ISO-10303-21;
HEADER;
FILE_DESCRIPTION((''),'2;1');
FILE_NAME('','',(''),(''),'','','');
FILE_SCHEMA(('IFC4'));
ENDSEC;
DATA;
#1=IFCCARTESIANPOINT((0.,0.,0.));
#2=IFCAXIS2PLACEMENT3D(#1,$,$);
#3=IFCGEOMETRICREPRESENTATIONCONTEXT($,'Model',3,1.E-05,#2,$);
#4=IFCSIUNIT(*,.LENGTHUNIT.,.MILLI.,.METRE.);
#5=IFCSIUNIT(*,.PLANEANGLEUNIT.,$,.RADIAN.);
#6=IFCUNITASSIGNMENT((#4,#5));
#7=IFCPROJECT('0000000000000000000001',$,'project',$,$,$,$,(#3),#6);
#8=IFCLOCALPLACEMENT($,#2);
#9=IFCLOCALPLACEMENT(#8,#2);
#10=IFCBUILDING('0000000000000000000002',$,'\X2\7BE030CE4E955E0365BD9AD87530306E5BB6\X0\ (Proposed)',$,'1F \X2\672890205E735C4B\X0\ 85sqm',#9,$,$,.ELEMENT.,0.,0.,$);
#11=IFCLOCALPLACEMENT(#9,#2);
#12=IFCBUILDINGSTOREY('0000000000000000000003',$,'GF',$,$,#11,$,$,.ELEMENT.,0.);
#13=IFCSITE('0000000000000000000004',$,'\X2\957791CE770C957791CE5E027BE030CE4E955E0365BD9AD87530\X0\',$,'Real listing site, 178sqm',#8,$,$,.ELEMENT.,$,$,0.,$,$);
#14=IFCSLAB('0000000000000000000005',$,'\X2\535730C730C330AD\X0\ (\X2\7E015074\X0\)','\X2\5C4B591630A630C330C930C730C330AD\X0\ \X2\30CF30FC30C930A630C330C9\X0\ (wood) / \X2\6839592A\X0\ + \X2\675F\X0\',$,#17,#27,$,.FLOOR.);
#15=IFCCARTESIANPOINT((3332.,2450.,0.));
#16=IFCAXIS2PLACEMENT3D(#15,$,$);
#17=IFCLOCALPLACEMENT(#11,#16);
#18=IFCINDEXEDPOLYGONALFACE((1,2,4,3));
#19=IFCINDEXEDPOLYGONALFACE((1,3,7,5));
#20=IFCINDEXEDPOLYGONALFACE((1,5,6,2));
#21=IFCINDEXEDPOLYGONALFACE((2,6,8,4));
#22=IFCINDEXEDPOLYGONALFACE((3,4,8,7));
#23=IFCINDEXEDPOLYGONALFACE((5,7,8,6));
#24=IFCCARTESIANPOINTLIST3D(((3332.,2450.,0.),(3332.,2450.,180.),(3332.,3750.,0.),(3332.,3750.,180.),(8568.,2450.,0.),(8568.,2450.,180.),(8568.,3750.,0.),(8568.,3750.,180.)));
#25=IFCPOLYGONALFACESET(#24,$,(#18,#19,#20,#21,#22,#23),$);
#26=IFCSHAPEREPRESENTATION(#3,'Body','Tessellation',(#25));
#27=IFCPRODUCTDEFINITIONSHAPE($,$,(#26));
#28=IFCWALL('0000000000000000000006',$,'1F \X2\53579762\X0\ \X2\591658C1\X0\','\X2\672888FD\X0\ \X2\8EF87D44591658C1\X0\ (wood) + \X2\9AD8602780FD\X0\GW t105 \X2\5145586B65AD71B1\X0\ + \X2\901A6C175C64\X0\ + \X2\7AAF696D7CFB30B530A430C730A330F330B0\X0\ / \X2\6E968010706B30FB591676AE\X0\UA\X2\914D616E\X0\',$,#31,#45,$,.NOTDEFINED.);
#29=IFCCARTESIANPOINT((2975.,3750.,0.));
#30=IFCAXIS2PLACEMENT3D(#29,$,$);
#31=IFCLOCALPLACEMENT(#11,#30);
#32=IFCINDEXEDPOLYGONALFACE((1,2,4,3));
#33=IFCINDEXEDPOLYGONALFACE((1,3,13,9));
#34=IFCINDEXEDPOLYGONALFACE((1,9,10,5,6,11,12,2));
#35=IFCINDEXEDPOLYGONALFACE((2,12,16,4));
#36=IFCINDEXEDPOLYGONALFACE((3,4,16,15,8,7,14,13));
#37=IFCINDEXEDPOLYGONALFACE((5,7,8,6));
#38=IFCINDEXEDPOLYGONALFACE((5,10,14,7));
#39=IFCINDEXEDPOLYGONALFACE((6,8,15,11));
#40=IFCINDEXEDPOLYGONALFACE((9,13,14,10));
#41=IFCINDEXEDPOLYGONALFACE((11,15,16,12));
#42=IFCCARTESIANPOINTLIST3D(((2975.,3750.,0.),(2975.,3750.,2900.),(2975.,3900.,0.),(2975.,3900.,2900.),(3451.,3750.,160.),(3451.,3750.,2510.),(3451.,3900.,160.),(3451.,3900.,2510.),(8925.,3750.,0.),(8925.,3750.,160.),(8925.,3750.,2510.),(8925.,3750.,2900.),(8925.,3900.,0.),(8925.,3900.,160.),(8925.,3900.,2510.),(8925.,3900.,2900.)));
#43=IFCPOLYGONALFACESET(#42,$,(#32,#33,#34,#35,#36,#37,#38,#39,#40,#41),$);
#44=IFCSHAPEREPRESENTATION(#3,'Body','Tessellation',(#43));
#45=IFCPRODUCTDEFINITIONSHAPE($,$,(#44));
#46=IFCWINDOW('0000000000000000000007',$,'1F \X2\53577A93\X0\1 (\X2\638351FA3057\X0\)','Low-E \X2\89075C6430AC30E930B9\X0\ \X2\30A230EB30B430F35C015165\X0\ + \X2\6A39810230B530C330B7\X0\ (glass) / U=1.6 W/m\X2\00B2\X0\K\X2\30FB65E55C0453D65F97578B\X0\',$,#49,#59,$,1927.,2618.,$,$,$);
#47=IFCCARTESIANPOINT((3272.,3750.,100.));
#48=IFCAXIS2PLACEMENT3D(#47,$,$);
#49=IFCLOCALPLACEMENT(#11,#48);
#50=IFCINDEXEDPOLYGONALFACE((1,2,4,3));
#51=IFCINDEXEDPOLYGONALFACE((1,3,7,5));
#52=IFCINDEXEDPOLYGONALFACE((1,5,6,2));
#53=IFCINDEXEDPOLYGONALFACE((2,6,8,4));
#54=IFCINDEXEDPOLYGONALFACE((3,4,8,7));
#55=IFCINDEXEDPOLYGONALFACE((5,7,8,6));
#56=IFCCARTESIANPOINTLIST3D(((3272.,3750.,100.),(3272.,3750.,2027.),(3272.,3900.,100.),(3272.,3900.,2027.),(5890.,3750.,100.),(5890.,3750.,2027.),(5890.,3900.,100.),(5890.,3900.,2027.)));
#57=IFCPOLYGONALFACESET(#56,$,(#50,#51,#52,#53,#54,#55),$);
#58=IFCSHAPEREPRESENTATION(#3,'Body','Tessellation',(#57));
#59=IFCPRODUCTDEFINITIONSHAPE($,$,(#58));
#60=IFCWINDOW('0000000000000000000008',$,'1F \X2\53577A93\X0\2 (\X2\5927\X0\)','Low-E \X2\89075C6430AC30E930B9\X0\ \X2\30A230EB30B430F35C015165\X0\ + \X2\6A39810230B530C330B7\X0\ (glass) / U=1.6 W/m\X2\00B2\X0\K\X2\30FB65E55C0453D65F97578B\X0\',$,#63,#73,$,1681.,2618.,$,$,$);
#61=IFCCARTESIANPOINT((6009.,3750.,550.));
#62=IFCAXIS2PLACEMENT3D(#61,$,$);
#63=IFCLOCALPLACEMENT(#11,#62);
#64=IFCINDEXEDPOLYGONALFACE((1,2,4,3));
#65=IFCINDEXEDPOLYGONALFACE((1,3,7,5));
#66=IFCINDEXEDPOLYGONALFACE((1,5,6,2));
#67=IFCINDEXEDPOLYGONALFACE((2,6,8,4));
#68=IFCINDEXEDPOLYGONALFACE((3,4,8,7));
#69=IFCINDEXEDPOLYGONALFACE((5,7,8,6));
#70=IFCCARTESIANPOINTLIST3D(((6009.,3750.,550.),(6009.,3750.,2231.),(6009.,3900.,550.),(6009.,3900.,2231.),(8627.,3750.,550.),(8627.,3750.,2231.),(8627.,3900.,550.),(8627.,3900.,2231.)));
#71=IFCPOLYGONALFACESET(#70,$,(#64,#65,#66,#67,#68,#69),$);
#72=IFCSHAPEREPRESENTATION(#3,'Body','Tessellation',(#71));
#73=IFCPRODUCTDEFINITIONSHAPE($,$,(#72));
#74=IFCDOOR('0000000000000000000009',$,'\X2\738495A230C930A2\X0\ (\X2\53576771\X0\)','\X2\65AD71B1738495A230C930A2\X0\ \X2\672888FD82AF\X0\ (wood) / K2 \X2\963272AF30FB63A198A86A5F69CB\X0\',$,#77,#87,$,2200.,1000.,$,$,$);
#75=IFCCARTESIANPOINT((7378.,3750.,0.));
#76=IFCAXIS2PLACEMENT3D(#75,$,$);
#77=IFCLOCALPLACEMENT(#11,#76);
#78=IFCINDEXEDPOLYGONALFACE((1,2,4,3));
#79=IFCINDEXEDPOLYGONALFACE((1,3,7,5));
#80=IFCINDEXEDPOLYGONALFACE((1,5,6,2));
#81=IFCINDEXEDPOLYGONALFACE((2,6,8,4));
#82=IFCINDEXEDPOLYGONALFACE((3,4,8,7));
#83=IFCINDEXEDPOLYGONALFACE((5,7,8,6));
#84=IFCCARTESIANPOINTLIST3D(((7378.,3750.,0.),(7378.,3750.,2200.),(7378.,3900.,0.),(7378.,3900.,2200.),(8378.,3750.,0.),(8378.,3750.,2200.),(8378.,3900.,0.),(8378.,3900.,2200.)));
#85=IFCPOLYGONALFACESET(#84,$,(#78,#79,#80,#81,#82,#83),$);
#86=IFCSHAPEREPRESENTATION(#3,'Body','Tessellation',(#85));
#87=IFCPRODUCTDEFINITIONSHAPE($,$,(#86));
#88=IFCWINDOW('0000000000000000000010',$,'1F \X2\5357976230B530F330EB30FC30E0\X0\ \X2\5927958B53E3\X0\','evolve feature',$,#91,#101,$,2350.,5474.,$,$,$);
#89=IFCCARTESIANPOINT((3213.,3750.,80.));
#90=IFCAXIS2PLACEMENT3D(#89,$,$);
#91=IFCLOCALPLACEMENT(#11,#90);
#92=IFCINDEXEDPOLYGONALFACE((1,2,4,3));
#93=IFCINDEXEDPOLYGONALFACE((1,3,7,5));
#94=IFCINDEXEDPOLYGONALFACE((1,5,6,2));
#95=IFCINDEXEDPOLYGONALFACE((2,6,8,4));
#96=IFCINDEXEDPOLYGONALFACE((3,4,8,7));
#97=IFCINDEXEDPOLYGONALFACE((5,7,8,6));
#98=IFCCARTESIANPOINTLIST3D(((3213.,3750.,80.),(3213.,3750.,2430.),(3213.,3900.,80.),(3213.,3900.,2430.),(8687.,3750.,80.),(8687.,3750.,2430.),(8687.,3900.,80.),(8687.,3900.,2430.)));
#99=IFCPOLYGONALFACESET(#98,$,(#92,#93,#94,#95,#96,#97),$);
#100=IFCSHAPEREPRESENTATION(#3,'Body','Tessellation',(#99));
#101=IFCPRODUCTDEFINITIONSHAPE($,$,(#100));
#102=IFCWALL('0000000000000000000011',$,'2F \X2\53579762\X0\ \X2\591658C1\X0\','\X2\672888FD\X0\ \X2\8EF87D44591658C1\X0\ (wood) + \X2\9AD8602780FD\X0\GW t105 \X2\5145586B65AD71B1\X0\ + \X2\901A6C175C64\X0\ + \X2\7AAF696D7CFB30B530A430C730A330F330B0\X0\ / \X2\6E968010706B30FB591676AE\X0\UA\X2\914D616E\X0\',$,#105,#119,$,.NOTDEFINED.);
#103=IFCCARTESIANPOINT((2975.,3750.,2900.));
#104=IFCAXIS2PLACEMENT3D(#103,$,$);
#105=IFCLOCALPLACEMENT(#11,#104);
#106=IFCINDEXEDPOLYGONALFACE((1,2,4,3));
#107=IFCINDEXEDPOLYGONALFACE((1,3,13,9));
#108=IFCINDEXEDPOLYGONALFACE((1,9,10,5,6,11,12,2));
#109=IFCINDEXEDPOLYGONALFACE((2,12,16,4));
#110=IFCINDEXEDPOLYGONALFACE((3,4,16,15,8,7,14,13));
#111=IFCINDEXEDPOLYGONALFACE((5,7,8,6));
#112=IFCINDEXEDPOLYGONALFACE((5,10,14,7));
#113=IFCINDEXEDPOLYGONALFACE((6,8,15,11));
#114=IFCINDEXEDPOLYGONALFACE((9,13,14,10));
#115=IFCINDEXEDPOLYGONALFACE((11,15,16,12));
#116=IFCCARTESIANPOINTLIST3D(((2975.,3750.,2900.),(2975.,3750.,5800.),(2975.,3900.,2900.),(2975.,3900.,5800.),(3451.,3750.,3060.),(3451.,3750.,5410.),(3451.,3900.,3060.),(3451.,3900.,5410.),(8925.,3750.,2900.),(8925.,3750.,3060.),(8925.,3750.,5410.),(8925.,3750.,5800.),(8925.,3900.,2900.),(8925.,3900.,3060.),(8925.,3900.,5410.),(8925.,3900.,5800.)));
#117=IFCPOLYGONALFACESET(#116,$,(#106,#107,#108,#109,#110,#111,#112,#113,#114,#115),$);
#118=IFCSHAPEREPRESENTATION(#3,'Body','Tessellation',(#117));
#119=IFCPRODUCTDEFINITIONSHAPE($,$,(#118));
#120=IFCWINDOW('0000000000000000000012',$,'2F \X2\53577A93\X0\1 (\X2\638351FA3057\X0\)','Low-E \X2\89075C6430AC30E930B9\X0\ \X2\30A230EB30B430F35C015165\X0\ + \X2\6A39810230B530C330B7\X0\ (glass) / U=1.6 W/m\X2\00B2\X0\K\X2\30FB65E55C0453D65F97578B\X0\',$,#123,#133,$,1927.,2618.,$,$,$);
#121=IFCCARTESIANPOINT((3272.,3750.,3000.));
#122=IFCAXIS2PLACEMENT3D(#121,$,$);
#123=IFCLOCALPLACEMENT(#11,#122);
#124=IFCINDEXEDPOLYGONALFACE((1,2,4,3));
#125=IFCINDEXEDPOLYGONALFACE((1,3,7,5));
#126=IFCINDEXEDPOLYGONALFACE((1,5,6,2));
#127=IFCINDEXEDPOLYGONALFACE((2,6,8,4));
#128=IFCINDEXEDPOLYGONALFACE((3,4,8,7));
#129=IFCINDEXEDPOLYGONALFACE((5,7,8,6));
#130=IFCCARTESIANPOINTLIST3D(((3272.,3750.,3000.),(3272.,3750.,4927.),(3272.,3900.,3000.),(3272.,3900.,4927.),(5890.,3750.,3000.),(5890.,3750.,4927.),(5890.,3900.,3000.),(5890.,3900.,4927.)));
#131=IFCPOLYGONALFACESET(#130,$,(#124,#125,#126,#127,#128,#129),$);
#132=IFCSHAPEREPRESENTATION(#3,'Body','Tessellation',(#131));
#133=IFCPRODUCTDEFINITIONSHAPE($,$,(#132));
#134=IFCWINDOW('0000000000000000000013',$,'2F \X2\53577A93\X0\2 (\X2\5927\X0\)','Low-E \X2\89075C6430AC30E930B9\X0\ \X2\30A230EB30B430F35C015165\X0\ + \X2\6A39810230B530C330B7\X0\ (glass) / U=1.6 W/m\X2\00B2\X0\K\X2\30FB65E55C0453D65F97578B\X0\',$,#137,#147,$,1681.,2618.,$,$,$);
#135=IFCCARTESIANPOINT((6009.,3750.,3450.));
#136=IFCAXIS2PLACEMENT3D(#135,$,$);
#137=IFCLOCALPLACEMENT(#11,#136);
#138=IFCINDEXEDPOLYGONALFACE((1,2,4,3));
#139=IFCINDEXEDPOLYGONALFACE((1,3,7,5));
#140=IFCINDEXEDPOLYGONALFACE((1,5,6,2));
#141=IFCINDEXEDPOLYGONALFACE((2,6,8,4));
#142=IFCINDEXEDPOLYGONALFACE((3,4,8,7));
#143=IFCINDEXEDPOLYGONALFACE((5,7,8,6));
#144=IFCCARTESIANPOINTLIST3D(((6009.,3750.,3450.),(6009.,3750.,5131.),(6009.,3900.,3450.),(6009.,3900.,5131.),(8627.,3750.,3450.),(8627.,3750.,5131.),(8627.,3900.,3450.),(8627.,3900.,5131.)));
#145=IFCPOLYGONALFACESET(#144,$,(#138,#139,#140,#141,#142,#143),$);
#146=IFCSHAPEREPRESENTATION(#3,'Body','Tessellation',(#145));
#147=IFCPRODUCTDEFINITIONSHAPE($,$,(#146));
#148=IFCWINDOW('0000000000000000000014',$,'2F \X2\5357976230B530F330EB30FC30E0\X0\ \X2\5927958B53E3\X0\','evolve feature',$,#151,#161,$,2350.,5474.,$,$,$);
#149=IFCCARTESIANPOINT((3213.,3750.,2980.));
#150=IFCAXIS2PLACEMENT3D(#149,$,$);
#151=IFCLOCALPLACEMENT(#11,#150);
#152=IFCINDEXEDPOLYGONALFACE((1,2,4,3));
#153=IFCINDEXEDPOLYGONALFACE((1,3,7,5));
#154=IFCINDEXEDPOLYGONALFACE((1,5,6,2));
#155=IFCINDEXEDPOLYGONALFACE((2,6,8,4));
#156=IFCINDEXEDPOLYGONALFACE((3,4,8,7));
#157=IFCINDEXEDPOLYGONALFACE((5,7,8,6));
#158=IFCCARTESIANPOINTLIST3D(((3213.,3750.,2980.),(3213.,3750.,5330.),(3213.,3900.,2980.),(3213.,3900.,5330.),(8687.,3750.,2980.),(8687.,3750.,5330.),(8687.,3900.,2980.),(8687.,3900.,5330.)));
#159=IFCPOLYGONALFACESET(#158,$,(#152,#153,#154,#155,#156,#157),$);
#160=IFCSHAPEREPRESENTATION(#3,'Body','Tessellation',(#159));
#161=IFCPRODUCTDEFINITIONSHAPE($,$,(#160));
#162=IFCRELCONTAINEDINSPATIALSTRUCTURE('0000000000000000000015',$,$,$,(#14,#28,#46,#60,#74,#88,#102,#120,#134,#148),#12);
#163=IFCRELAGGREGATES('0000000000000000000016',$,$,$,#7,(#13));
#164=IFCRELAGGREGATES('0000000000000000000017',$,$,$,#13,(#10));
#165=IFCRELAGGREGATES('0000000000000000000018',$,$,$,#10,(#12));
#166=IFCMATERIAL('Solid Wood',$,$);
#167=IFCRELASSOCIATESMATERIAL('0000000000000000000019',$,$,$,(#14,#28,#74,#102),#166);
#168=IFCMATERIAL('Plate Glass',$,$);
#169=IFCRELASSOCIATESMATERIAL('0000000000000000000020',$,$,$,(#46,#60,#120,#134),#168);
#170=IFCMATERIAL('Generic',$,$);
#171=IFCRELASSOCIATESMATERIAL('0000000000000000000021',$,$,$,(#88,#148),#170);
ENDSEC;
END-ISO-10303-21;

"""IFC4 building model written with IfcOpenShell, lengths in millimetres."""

from ifc_helpers import new_model, si_unit, frame, frame_2d, origin, place, context, project, spatial, rectangle, extrude, material, element, fill, save


model = new_model("IFC4")

# Units and contexts
model_context = context("Model", 3, precision=1e-05, world=origin())
ifc_project = project(units=[si_unit("LENGTHUNIT", "METRE", prefix="MILLI"), si_unit("PLANEANGLEUNIT", "RADIAN")], contexts=[model_context])

# Site, building, storey
site_placement = place(None, origin())
site = spatial("IfcSite", under=ifc_project, at=site_placement, Name="長野県長野市篠ノ井布施高田", ObjectType="Real listing site, 178sqm", CompositionType="ELEMENT", RefElevation=0.0)
building_placement = place(site_placement, origin())
building = spatial("IfcBuilding", under=site, at=building_placement, Name="篠ノ井布施高田の家 (Proposed)", ObjectType="1F 木造平屋 85sqm", CompositionType="ELEMENT", ElevationOfRefHeight=0.0, ElevationOfTerrain=0.0)
storey_placement = place(building_placement, origin())
storey = spatial("IfcBuildingStorey", under=building, at=storey_placement, Name="GF", CompositionType="ELEMENT", Elevation=0.0)

# Slab
ifc_material_1 = material(Name="Solid Wood")
slab_1_placement = place(storey_placement, frame((3332.0, 2450.0, 0.0)))
element("IfcSlab", 1, at=slab_1_placement, inside=storey, material=ifc_material_1, Name="南デッキ (縁側)", Description="屋外ウッドデッキ ハードウッド (wood) / 根太 + 束", PredefinedType="FLOOR", context=model_context, shape_type="SweptSolid", body=[
    extrude(rectangle(XDim=5236.0, YDim=1300.0, at=frame_2d((2618.0, 650.0))), frame((3332.0, 2450.0, 0.0)), (0.0, 0.0, 1.0), 180.0),
])
ifc_material_2 = material(Name="Generic")

# Wall, openings, windows, door
wall_1_placement = place(storey_placement, frame((2975.0, 3750.0, 0.0)))
wall_1 = element("IfcWall", 2, at=wall_1_placement, inside=storey, material=ifc_material_1, Name="1F 南面 外壁", Description="木製 軸組外壁 (wood) + 高性能GW t105 充填断熱 + 通気層 + 窯業系サイディング / 準耐火・外皮UA配慮", PredefinedType="NOTDEFINED", context=model_context, shape_type="SweptSolid", body=[
    extrude(rectangle(XDim=5950.0, YDim=150.0, at=frame_2d((2975.0, 75.0))), frame((2975.0, 3750.0, 0.0)), (0.0, 0.0, 1.0), 2900.0),
])
opening_1_placement = place(storey_placement, frame((3272.0, 3750.0, 100.0)))
opening_1 = element("IfcOpeningElement", 3, at=opening_1_placement, cuts=wall_1, PredefinedType="NOTDEFINED", context=model_context, shape_type="SweptSolid", body=[
    extrude(rectangle(XDim=2618.0, YDim=150.0, at=frame_2d((1309.0, 75.0))), frame((3272.0, 3750.0, 100.0)), (0.0, 0.0, 1.0), 1927.0),
])
opening_2_placement = place(storey_placement, frame((6009.0, 3750.0, 550.0)))
opening_2 = element("IfcOpeningElement", 4, at=opening_2_placement, cuts=wall_1, PredefinedType="NOTDEFINED", context=model_context, shape_type="SweptSolid", body=[
    extrude(rectangle(XDim=2618.0, YDim=150.0, at=frame_2d((1309.0, 75.0))), frame((6009.0, 3750.0, 550.0)), (0.0, 0.0, 1.0), 1681.0),
])
opening_3_placement = place(storey_placement, frame((7378.0, 3750.0, 0.0)))
opening_3 = element("IfcOpeningElement", 5, at=opening_3_placement, cuts=wall_1, PredefinedType="NOTDEFINED", context=model_context, shape_type="SweptSolid", body=[
    extrude(rectangle(XDim=1000.0, YDim=150.0, at=frame_2d((500.0, 75.0))), frame((7378.0, 3750.0, 0.0)), (0.0, 0.0, 1.0), 2200.0),
])
opening_4_placement = place(storey_placement, frame((3213.0, 3750.0, 80.0)))
opening_4 = element("IfcOpeningElement", 6, at=opening_4_placement, cuts=wall_1, PredefinedType="NOTDEFINED", context=model_context, shape_type="SweptSolid", body=[
    extrude(rectangle(XDim=5474.0, YDim=150.0, at=frame_2d((2737.0, 75.0))), frame((3213.0, 3750.0, 80.0)), (0.0, 0.0, 1.0), 2350.0),
])
ifc_material_3 = material(Name="Plate Glass")
window_1_placement = place(storey_placement, frame((3272.0, 3750.0, 100.0)))
window_1 = element("IfcWindow", 7, at=window_1_placement, inside=storey, material=ifc_material_3, Name="1F 南窓1 (掃出し)", Description="Low-E 複層ガラス アルゴン封入 + 樹脂サッシ (glass) / U=1.6 W/m²K・日射取得型", OverallHeight=1927.0, OverallWidth=2618.0, context=model_context, shape_type="SweptSolid", body=[
    extrude(rectangle(XDim=2618.0, YDim=150.0, at=frame_2d((1309.0, 75.0))), frame((3272.0, 3750.0, 100.0)), (0.0, 0.0, 1.0), 1927.0),
])
fill(opening_1, window_1)
window_2_placement = place(storey_placement, frame((6009.0, 3750.0, 550.0)))
window_2 = element("IfcWindow", 8, at=window_2_placement, inside=storey, material=ifc_material_3, Name="1F 南窓2 (大)", Description="Low-E 複層ガラス アルゴン封入 + 樹脂サッシ (glass) / U=1.6 W/m²K・日射取得型", OverallHeight=1681.0, OverallWidth=2618.0, context=model_context, shape_type="SweptSolid", body=[
    extrude(rectangle(XDim=2618.0, YDim=150.0, at=frame_2d((1309.0, 75.0))), frame((6009.0, 3750.0, 550.0)), (0.0, 0.0, 1.0), 1681.0),
])
fill(opening_2, window_2)
door_placement = place(storey_placement, frame((7378.0, 3750.0, 0.0)))
door = element("IfcDoor", 9, at=door_placement, inside=storey, material=ifc_material_1, Name="玄関ドア (南東)", Description="断熱玄関ドア 木製芯 (wood) / K2 防犯・採風機構", OverallHeight=2200.0, OverallWidth=1000.0, context=model_context, shape_type="SweptSolid", body=[
    extrude(rectangle(XDim=1000.0, YDim=150.0, at=frame_2d((500.0, 75.0))), frame((7378.0, 3750.0, 0.0)), (0.0, 0.0, 1.0), 2200.0),
])
fill(opening_3, door)
window_3_placement = place(storey_placement, frame((3213.0, 3750.0, 80.0)))
window_3 = element("IfcWindow", 10, at=window_3_placement, inside=storey, material=ifc_material_2, Name="1F 南面サンルーム 大開口", Description="evolve feature", OverallHeight=2350.0, OverallWidth=5474.0, context=model_context, shape_type="SweptSolid", body=[
    extrude(rectangle(XDim=5474.0, YDim=150.0, at=frame_2d((2737.0, 75.0))), frame((3213.0, 3750.0, 80.0)), (0.0, 0.0, 1.0), 2350.0),
])
fill(opening_4, window_3)

# Wall, openings, windows
wall_2_placement = place(storey_placement, frame((2975.0, 3750.0, 2900.0)))
wall_2 = element("IfcWall", 11, at=wall_2_placement, inside=storey, material=ifc_material_1, Name="2F 南面 外壁", Description="木製 軸組外壁 (wood) + 高性能GW t105 充填断熱 + 通気層 + 窯業系サイディング / 準耐火・外皮UA配慮", PredefinedType="NOTDEFINED", context=model_context, shape_type="SweptSolid", body=[
    extrude(rectangle(XDim=5950.0, YDim=150.0, at=frame_2d((2975.0, 75.0))), frame((2975.0, 3750.0, 2900.0)), (0.0, 0.0, 1.0), 2900.0),
])
opening_5_placement = place(storey_placement, frame((3272.0, 3750.0, 3000.0)))
opening_5 = element("IfcOpeningElement", 12, at=opening_5_placement, cuts=wall_2, PredefinedType="NOTDEFINED", context=model_context, shape_type="SweptSolid", body=[
    extrude(rectangle(XDim=2618.0, YDim=150.0, at=frame_2d((1309.0, 75.0))), frame((3272.0, 3750.0, 3000.0)), (0.0, 0.0, 1.0), 1927.0),
])
opening_6_placement = place(storey_placement, frame((6009.0, 3750.0, 3450.0)))
opening_6 = element("IfcOpeningElement", 13, at=opening_6_placement, cuts=wall_2, PredefinedType="NOTDEFINED", context=model_context, shape_type="SweptSolid", body=[
    extrude(rectangle(XDim=2618.0, YDim=150.0, at=frame_2d((1309.0, 75.0))), frame((6009.0, 3750.0, 3450.0)), (0.0, 0.0, 1.0), 1681.0),
])
opening_7_placement = place(storey_placement, frame((3213.0, 3750.0, 2980.0)))
opening_7 = element("IfcOpeningElement", 14, at=opening_7_placement, cuts=wall_2, PredefinedType="NOTDEFINED", context=model_context, shape_type="SweptSolid", body=[
    extrude(rectangle(XDim=5474.0, YDim=150.0, at=frame_2d((2737.0, 75.0))), frame((3213.0, 3750.0, 2980.0)), (0.0, 0.0, 1.0), 2350.0),
])
window_4_placement = place(storey_placement, frame((3272.0, 3750.0, 3000.0)))
window_4 = element("IfcWindow", 15, at=window_4_placement, inside=storey, material=ifc_material_3, Name="2F 南窓1 (掃出し)", Description="Low-E 複層ガラス アルゴン封入 + 樹脂サッシ (glass) / U=1.6 W/m²K・日射取得型", OverallHeight=1927.0, OverallWidth=2618.0, context=model_context, shape_type="SweptSolid", body=[
    extrude(rectangle(XDim=2618.0, YDim=150.0, at=frame_2d((1309.0, 75.0))), frame((3272.0, 3750.0, 3000.0)), (0.0, 0.0, 1.0), 1927.0),
])
fill(opening_5, window_4)
window_5_placement = place(storey_placement, frame((6009.0, 3750.0, 3450.0)))
window_5 = element("IfcWindow", 16, at=window_5_placement, inside=storey, material=ifc_material_3, Name="2F 南窓2 (大)", Description="Low-E 複層ガラス アルゴン封入 + 樹脂サッシ (glass) / U=1.6 W/m²K・日射取得型", OverallHeight=1681.0, OverallWidth=2618.0, context=model_context, shape_type="SweptSolid", body=[
    extrude(rectangle(XDim=2618.0, YDim=150.0, at=frame_2d((1309.0, 75.0))), frame((6009.0, 3750.0, 3450.0)), (0.0, 0.0, 1.0), 1681.0),
])
fill(opening_6, window_5)
window_6_placement = place(storey_placement, frame((3213.0, 3750.0, 2980.0)))
window_6 = element("IfcWindow", 17, at=window_6_placement, inside=storey, material=ifc_material_2, Name="2F 南面サンルーム 大開口", Description="evolve feature", OverallHeight=2350.0, OverallWidth=5474.0, context=model_context, shape_type="SweptSolid", body=[
    extrude(rectangle(XDim=5474.0, YDim=150.0, at=frame_2d((2737.0, 75.0))), frame((3213.0, 3750.0, 2980.0)), (0.0, 0.0, 1.0), 2350.0),
])
fill(opening_7, window_6)

save(model, "model.ifc")
